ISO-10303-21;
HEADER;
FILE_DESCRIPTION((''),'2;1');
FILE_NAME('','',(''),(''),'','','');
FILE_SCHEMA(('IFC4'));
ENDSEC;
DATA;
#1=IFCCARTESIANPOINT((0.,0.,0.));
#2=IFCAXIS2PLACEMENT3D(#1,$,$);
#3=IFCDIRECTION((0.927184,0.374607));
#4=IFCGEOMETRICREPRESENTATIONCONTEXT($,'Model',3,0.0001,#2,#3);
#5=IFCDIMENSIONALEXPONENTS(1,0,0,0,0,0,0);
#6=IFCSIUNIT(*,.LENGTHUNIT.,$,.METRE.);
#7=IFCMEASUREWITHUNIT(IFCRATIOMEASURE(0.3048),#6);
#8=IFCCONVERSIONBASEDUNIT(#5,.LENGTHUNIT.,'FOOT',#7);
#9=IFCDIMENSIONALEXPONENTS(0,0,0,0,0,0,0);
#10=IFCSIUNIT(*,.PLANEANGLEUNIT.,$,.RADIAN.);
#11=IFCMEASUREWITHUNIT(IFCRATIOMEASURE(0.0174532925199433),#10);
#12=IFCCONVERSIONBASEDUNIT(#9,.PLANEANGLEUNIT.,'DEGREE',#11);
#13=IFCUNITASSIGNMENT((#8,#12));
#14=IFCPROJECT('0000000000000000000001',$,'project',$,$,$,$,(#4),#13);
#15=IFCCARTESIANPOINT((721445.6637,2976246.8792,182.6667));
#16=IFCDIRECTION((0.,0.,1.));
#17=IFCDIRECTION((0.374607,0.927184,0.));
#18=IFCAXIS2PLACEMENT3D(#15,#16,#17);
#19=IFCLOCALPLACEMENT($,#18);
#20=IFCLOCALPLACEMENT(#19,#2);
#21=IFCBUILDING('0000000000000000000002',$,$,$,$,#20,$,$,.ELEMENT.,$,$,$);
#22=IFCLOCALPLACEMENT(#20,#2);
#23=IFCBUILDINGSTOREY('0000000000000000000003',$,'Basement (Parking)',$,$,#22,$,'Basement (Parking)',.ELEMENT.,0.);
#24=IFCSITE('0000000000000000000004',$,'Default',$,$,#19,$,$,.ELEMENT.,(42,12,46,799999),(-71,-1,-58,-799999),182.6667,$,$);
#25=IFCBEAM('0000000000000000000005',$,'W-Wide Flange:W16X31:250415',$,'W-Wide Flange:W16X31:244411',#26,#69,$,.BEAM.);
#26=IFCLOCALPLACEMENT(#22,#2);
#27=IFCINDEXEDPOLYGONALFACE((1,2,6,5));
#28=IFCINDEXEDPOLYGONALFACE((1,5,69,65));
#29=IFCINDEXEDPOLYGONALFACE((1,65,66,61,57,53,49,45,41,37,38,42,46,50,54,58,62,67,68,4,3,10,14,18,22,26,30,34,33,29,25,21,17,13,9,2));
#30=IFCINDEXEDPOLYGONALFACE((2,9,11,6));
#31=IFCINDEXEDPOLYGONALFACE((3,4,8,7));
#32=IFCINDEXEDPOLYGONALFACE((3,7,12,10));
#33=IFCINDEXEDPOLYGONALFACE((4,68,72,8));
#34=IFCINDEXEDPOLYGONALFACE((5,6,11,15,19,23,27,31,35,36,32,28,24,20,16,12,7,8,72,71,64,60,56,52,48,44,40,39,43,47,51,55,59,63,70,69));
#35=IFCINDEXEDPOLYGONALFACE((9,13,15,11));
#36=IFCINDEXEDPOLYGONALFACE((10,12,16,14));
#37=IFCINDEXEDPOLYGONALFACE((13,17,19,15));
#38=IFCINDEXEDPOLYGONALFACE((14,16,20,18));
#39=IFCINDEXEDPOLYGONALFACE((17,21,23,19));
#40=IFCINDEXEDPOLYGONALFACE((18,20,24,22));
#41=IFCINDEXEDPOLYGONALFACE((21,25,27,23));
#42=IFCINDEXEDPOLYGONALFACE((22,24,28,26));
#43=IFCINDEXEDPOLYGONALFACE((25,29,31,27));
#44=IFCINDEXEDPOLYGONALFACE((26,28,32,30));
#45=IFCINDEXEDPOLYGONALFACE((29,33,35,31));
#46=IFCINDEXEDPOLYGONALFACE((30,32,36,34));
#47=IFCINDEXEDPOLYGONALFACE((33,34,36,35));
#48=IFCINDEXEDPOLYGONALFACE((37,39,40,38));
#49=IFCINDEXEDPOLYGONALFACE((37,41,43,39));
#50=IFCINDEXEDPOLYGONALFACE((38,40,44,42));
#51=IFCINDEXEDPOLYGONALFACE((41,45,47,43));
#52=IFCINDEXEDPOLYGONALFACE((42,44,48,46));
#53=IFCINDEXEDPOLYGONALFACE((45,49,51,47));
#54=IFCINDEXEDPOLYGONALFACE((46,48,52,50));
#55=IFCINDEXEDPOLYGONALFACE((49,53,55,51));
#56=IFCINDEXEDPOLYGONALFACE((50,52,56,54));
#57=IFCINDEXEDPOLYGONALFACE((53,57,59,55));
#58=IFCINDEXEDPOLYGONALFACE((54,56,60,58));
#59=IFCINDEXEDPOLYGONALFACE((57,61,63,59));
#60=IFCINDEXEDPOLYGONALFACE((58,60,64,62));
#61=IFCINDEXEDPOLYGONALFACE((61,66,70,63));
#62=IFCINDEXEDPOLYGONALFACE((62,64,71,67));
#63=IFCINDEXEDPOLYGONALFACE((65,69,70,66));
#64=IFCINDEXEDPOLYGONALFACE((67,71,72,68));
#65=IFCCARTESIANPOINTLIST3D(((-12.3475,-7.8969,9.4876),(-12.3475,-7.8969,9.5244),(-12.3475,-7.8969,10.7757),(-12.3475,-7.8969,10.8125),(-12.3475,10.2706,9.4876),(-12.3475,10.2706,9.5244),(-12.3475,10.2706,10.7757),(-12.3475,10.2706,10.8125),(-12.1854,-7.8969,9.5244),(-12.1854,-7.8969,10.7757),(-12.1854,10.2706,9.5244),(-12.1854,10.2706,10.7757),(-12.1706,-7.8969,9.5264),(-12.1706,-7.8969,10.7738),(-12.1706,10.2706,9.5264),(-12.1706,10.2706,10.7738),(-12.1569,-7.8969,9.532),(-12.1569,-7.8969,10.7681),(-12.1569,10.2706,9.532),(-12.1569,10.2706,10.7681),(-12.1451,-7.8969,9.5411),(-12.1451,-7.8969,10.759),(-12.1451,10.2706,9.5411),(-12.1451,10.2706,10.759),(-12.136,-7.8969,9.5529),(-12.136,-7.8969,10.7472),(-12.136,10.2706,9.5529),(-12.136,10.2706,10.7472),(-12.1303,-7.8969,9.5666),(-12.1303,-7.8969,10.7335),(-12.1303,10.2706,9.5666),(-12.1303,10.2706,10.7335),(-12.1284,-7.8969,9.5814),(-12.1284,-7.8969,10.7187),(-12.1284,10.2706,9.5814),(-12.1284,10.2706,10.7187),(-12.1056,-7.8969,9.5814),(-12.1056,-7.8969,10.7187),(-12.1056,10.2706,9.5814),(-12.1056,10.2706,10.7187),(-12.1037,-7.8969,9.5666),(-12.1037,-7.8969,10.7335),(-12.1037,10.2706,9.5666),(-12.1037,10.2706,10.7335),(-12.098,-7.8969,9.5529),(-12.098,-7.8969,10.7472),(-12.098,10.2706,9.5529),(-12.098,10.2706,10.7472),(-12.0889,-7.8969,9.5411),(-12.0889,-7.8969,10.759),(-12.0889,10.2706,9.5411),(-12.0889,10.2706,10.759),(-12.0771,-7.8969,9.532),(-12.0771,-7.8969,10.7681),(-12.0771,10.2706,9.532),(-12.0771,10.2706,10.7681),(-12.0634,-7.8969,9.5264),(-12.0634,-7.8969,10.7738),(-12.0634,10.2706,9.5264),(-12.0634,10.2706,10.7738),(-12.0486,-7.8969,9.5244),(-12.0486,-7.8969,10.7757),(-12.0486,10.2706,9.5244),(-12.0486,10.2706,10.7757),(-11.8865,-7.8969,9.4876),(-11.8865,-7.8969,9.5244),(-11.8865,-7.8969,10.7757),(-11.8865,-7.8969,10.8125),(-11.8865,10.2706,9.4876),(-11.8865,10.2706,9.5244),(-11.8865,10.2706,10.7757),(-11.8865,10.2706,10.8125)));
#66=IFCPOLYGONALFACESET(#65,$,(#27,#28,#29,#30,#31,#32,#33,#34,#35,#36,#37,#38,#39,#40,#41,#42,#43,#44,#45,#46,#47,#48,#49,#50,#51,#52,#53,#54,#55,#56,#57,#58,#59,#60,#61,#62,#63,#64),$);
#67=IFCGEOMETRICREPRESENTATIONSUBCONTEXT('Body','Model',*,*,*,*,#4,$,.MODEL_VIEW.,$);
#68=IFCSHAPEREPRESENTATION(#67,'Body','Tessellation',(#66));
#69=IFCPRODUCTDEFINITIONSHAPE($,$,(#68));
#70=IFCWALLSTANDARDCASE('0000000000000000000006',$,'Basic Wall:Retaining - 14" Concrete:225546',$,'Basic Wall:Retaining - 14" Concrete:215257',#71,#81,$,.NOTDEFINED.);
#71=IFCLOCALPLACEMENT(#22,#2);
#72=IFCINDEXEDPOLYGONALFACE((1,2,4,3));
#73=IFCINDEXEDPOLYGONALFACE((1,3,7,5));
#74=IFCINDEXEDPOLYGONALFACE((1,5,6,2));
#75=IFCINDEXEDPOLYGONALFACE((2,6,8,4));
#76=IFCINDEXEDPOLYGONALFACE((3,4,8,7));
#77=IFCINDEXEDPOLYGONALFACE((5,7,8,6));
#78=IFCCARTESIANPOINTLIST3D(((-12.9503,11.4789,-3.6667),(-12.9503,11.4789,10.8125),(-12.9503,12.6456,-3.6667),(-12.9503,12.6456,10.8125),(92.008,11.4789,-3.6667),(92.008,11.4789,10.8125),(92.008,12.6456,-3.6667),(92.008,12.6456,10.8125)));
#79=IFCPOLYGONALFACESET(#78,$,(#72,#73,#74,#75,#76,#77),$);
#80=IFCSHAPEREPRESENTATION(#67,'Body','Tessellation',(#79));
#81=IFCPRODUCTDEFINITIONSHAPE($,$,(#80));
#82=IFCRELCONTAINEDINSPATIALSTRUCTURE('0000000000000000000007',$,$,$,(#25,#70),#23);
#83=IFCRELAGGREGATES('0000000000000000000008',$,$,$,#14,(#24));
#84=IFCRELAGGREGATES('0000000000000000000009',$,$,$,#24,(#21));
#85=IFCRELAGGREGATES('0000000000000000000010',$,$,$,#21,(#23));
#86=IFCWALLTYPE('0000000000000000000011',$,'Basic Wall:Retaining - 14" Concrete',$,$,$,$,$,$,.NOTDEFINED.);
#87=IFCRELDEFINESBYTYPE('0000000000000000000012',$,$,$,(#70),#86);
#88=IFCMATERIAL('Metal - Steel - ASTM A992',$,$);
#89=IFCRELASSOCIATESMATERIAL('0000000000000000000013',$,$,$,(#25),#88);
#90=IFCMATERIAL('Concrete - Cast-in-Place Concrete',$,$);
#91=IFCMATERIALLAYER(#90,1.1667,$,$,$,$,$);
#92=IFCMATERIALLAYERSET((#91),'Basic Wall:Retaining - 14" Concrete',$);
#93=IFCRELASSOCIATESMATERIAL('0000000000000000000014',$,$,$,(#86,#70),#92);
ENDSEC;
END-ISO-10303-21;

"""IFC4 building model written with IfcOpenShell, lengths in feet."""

from ifc_helpers import new_model, entity, si_unit, converted_unit, direction, frame, frame_2d, origin, place, context, subcontext, project, spatial, rectangle, i_section, extrude, material, layer, layer_set, layer_usage, type_object, element, save


model = new_model("IFC4")

# Units and contexts
model_context = context("Model", 3, precision=0.0001, world=origin(), true_north=direction((0.927184, 0.374607)))
body_context = subcontext(model_context, "Body", "Model", "MODEL_VIEW")
ifc_project = project(units=[converted_unit("LENGTHUNIT", "FOOT", entity("IfcRatioMeasure", 0.3048), si_unit("LENGTHUNIT", "METRE"), dimensions=[1, 0, 0, 0, 0, 0, 0]), converted_unit("PLANEANGLEUNIT", "DEGREE", entity("IfcRatioMeasure", 0.0174532925199433), si_unit("PLANEANGLEUNIT", "RADIAN"), dimensions=[0, 0, 0, 0, 0, 0, 0])], contexts=[model_context])

# Site, building, storey
site_placement = place(None, frame((721445.6637, 2976246.8792, 182.6667), z_axis=(0.0, 0.0, 1.0), x_axis=(0.374607, 0.927184, 0.0)))
site = spatial("IfcSite", under=ifc_project, at=site_placement, Name="Default", CompositionType="ELEMENT", RefLatitude=(42, 12, 46, 799999), RefLongitude=(-71, -1, -58, -799999), RefElevation=182.6667)
building_placement = place(site_placement, origin())
building = spatial("IfcBuilding", under=site, at=building_placement, CompositionType="ELEMENT")
storey_placement = place(building_placement, origin())
storey = spatial("IfcBuildingStorey", under=building, at=storey_placement, Name="Basement (Parking)", LongName="Basement (Parking)", CompositionType="ELEMENT", Elevation=0.0)

# Shared definitions
ifc_material_1 = material(Name="Concrete - Cast-in-Place Concrete")

# Shared definitions
ifc_material_2 = material(Name="Metal - Steel - ASTM A992")

# Beam
beam_1_placement = place(storey_placement, frame((-12.117, 11.6456, 10.8125), z_axis=(0.0, 0.0, 1.0), x_axis=(0.0, -1.0, 0.0)))
element("IfcBeam", 1, at=beam_1_placement, inside=storey, material=ifc_material_2, Name="W-Wide Flange:W16X31:250415", ObjectType="W-Wide Flange:W16X31:244411", PredefinedType="BEAM", context=body_context, shape_type="SweptSolid", body=[
    extrude(i_section(OverallWidth=0.4609, OverallDepth=1.3249, WebThickness=0.0228, FlangeThickness=0.0368, FilletRadius=0.057, at=frame_2d((0.0, 0.0), x_axis=(0.0, 1.0))), frame((1.375, 0.0, -0.6624), z_axis=(1.0, 0.0, 0.0), x_axis=(0.0, 0.0, -1.0)), (0.0, 0.0, 1.0), 18.1675),
])

# Wall
ifc_layer = layer(ifc_material_1, 1.1667)
ifc_layer_set = layer_set([ifc_layer], Name="Basic Wall:Retaining - 14\" Concrete")
ifc_layer_usage = layer_usage(ifc_layer_set, "AXIS2", "NEGATIVE", 0.5833)
wall_type = type_object("IfcWallType", Name="Basic Wall:Retaining - 14\" Concrete", PredefinedType="NOTDEFINED", material=ifc_layer_set)
wall_placement = place(storey_placement, frame((-12.9503, 12.0622, -3.6667)))
element("IfcWallStandardCase", 2, at=wall_placement, inside=storey, type_object=wall_type, material=ifc_layer_usage, Name="Basic Wall:Retaining - 14\" Concrete:225546", ObjectType="Basic Wall:Retaining - 14\" Concrete:215257", PredefinedType="NOTDEFINED", context=body_context, shape_type="SweptSolid", body=[
    extrude(rectangle(XDim=104.9583, YDim=1.1667, at=frame_2d((52.4792, 0.0), x_axis=(-1.0, 0.0))), origin(), (0.0, 0.0, 1.0), 14.4792),
])

save(model, "model.ifc")
